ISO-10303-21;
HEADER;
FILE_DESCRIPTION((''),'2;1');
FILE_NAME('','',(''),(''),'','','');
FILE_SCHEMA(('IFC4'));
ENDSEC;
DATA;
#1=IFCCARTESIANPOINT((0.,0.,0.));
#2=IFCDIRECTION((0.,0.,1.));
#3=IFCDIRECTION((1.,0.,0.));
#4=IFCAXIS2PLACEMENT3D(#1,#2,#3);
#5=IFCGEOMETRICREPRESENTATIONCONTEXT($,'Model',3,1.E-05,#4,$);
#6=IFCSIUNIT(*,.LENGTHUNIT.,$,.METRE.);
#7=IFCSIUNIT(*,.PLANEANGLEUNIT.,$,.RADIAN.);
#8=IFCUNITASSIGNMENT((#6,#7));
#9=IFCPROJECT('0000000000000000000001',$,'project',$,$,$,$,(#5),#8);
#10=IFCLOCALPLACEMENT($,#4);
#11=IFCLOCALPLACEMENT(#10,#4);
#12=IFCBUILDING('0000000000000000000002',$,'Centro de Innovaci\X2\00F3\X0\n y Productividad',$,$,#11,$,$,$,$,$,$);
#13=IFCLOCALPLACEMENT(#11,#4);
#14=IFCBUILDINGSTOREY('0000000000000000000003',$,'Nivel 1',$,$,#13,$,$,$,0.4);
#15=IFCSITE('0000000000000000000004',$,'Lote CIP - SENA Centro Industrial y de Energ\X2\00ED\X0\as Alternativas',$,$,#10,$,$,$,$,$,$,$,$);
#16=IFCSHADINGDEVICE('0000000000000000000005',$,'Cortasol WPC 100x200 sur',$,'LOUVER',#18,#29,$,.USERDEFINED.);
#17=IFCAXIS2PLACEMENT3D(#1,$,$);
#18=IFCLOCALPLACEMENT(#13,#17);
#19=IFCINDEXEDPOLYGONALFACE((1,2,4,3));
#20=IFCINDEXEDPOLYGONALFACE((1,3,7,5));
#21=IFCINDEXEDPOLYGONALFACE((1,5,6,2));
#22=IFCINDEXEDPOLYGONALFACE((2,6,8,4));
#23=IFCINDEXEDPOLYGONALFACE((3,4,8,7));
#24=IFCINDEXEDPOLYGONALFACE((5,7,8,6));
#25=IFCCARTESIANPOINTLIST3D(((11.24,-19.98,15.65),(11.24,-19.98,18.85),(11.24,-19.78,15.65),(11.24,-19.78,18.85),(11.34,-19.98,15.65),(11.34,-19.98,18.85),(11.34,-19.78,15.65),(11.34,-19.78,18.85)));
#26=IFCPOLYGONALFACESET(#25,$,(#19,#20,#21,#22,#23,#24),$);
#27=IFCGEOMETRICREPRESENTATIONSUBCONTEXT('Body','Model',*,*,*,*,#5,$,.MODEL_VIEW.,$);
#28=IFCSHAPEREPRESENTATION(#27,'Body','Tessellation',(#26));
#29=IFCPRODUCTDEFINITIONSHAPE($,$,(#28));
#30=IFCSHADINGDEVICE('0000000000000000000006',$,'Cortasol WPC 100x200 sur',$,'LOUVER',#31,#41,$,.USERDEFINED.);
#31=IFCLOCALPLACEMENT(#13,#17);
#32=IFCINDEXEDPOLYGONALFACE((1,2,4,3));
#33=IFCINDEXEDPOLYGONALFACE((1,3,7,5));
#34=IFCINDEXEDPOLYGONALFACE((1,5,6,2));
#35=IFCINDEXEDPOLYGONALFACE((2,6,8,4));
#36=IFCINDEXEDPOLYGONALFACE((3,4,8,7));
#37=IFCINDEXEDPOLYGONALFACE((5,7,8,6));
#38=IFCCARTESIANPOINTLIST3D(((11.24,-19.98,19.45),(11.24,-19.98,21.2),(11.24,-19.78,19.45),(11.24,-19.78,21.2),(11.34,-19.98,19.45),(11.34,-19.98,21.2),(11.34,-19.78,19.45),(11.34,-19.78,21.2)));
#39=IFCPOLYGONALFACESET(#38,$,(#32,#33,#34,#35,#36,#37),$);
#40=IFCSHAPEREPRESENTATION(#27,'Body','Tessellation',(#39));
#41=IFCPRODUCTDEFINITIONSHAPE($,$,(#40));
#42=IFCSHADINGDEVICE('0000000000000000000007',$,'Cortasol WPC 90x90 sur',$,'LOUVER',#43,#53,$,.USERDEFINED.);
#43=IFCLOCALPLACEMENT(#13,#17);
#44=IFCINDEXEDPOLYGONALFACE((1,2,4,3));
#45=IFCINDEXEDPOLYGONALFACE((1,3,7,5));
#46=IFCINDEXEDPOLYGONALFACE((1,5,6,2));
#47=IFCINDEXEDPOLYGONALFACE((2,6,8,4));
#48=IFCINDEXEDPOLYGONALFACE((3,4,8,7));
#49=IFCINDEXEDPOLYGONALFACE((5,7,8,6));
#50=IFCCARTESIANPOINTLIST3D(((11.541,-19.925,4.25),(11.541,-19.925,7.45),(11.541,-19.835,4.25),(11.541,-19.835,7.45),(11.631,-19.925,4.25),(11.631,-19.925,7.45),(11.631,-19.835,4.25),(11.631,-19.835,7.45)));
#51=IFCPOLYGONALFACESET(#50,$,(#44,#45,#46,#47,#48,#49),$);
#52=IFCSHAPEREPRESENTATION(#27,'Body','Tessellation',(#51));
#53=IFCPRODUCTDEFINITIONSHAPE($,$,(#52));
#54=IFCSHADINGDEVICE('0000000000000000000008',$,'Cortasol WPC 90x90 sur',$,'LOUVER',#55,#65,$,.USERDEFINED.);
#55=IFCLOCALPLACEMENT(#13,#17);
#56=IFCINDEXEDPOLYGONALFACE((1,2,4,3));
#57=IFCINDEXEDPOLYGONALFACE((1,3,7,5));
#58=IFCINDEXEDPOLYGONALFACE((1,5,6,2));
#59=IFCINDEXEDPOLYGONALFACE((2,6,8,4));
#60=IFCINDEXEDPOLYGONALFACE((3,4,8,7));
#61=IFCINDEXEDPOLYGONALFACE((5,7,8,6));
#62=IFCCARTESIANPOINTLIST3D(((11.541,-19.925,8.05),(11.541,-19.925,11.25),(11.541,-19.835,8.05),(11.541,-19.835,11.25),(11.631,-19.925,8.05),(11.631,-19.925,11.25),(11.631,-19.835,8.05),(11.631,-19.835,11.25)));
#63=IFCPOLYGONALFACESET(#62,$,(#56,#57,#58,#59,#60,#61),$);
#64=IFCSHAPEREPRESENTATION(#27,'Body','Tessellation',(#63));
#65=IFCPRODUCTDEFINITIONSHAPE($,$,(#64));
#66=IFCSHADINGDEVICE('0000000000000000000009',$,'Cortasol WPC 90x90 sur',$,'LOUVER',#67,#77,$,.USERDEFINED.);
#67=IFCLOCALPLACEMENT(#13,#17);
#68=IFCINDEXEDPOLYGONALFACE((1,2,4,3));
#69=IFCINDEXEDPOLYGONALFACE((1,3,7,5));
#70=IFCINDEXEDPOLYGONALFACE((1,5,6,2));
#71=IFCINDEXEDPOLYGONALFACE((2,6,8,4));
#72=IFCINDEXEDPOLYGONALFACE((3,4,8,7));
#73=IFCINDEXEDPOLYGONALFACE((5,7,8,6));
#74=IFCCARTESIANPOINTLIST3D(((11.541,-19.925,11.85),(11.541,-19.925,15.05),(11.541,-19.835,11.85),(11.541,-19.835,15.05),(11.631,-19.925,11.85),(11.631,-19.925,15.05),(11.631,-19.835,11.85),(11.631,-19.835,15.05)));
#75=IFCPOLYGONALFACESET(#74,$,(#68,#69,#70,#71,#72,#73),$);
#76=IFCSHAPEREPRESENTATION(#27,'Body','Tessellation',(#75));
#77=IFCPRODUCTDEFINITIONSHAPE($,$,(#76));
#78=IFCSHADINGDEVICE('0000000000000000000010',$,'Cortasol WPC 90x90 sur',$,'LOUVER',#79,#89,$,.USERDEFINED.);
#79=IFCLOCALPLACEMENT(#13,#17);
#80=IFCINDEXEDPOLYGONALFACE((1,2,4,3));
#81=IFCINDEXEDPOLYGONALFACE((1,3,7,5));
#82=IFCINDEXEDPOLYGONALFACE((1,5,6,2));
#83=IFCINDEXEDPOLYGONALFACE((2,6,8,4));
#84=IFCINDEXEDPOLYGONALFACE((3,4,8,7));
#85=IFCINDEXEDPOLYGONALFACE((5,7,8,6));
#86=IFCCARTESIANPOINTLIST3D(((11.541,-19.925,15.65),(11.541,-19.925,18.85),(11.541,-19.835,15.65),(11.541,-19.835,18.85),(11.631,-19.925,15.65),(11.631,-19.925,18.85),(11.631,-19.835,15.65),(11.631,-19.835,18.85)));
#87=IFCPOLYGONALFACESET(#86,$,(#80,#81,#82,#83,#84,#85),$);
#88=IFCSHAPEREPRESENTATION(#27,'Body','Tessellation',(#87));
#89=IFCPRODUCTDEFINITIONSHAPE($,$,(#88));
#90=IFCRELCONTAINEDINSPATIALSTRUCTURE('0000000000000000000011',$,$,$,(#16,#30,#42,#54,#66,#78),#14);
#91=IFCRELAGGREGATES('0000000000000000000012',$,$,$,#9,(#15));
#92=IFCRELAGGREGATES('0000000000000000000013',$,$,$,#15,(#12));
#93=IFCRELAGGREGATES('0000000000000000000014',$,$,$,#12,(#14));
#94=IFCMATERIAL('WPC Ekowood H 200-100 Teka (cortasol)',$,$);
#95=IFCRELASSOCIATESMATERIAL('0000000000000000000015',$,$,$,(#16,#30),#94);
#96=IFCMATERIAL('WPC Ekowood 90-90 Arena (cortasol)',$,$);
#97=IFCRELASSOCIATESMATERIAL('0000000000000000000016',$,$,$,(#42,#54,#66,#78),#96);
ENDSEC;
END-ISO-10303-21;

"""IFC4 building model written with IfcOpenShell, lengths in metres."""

from ifc_helpers import new_model, si_unit, frame, origin_with_axes, place, context, subcontext, project, spatial, polyline, outline, extrude, material, element, save


model = new_model("IFC4")

# Units and contexts
model_context = context("Model", 3, precision=1e-05, world=origin_with_axes())
body_context = subcontext(model_context, "Body", "Model", "MODEL_VIEW")
ifc_project = project(units=[si_unit("LENGTHUNIT", "METRE"), si_unit("PLANEANGLEUNIT", "RADIAN")], contexts=[model_context])

# Site, building, storey
site_placement = place(None, origin_with_axes())
site = spatial("IfcSite", under=ifc_project, at=site_placement, Name="Lote CIP - SENA Centro Industrial y de Energías Alternativas")
building_placement = place(site_placement, origin_with_axes())
building = spatial("IfcBuilding", under=site, at=building_placement, Name="Centro de Innovación y Productividad")
storey_placement = place(building_placement, origin_with_axes())
storey = spatial("IfcBuildingStorey", under=building, at=storey_placement, Name="Nivel 1", Elevation=0.4)

# Shading devices
ifc_material_1 = material(Name="WPC Ekowood 90-90 Arena (cortasol)")
ifc_material_2 = material(Name="WPC Ekowood H 200-100 Teka (cortasol)")
shading_device_1_placement = place(storey_placement, origin_with_axes())
element("IfcShadingDevice", 1, at=shading_device_1_placement, inside=storey, material=ifc_material_2, Name="Cortasol WPC 100x200 sur", ObjectType="LOUVER", PredefinedType="USERDEFINED", context=body_context, shape_type="SweptSolid", body=[
    extrude(outline(polyline([(11.24, -19.98), (11.24, -19.78), (11.34, -19.78), (11.34, -19.98), (11.24, -19.98)])), frame((0.0, 0.0, 15.65)), (0.0, 0.0, 1.0), 3.2),
])
shading_device_2_placement = place(storey_placement, origin_with_axes())
element("IfcShadingDevice", 2, at=shading_device_2_placement, inside=storey, material=ifc_material_2, Name="Cortasol WPC 100x200 sur", ObjectType="LOUVER", PredefinedType="USERDEFINED", context=body_context, shape_type="SweptSolid", body=[
    extrude(outline(polyline([(11.24, -19.98), (11.24, -19.78), (11.34, -19.78), (11.34, -19.98), (11.24, -19.98)])), frame((0.0, 0.0, 19.45)), (0.0, 0.0, 1.0), 1.75),
])
shading_device_3_placement = place(storey_placement, origin_with_axes())
element("IfcShadingDevice", 3, at=shading_device_3_placement, inside=storey, material=ifc_material_1, Name="Cortasol WPC 90x90 sur", ObjectType="LOUVER", PredefinedType="USERDEFINED", context=body_context, shape_type="SweptSolid", body=[
    extrude(outline(polyline([(11.541, -19.925), (11.541, -19.835), (11.631, -19.835), (11.631, -19.925), (11.541, -19.925)])), frame((0.0, 0.0, 4.25)), (0.0, 0.0, 1.0), 3.2),
])
shading_device_4_placement = place(storey_placement, origin_with_axes())
element("IfcShadingDevice", 4, at=shading_device_4_placement, inside=storey, material=ifc_material_1, Name="Cortasol WPC 90x90 sur", ObjectType="LOUVER", PredefinedType="USERDEFINED", context=body_context, shape_type="SweptSolid", body=[
    extrude(outline(polyline([(11.541, -19.925), (11.541, -19.835), (11.631, -19.835), (11.631, -19.925), (11.541, -19.925)])), frame((0.0, 0.0, 8.05)), (0.0, 0.0, 1.0), 3.2),
])
shading_device_5_placement = place(storey_placement, origin_with_axes())
element("IfcShadingDevice", 5, at=shading_device_5_placement, inside=storey, material=ifc_material_1, Name="Cortasol WPC 90x90 sur", ObjectType="LOUVER", PredefinedType="USERDEFINED", context=body_context, shape_type="SweptSolid", body=[
    extrude(outline(polyline([(11.541, -19.925), (11.541, -19.835), (11.631, -19.835), (11.631, -19.925), (11.541, -19.925)])), frame((0.0, 0.0, 11.85)), (0.0, 0.0, 1.0), 3.2),
])
shading_device_6_placement = place(storey_placement, origin_with_axes())
element("IfcShadingDevice", 6, at=shading_device_6_placement, inside=storey, material=ifc_material_1, Name="Cortasol WPC 90x90 sur", ObjectType="LOUVER", PredefinedType="USERDEFINED", context=body_context, shape_type="SweptSolid", body=[
    extrude(outline(polyline([(11.541, -19.925), (11.541, -19.835), (11.631, -19.835), (11.631, -19.925), (11.541, -19.925)])), frame((0.0, 0.0, 15.65)), (0.0, 0.0, 1.0), 3.2),
])

save(model, "model.ifc")
